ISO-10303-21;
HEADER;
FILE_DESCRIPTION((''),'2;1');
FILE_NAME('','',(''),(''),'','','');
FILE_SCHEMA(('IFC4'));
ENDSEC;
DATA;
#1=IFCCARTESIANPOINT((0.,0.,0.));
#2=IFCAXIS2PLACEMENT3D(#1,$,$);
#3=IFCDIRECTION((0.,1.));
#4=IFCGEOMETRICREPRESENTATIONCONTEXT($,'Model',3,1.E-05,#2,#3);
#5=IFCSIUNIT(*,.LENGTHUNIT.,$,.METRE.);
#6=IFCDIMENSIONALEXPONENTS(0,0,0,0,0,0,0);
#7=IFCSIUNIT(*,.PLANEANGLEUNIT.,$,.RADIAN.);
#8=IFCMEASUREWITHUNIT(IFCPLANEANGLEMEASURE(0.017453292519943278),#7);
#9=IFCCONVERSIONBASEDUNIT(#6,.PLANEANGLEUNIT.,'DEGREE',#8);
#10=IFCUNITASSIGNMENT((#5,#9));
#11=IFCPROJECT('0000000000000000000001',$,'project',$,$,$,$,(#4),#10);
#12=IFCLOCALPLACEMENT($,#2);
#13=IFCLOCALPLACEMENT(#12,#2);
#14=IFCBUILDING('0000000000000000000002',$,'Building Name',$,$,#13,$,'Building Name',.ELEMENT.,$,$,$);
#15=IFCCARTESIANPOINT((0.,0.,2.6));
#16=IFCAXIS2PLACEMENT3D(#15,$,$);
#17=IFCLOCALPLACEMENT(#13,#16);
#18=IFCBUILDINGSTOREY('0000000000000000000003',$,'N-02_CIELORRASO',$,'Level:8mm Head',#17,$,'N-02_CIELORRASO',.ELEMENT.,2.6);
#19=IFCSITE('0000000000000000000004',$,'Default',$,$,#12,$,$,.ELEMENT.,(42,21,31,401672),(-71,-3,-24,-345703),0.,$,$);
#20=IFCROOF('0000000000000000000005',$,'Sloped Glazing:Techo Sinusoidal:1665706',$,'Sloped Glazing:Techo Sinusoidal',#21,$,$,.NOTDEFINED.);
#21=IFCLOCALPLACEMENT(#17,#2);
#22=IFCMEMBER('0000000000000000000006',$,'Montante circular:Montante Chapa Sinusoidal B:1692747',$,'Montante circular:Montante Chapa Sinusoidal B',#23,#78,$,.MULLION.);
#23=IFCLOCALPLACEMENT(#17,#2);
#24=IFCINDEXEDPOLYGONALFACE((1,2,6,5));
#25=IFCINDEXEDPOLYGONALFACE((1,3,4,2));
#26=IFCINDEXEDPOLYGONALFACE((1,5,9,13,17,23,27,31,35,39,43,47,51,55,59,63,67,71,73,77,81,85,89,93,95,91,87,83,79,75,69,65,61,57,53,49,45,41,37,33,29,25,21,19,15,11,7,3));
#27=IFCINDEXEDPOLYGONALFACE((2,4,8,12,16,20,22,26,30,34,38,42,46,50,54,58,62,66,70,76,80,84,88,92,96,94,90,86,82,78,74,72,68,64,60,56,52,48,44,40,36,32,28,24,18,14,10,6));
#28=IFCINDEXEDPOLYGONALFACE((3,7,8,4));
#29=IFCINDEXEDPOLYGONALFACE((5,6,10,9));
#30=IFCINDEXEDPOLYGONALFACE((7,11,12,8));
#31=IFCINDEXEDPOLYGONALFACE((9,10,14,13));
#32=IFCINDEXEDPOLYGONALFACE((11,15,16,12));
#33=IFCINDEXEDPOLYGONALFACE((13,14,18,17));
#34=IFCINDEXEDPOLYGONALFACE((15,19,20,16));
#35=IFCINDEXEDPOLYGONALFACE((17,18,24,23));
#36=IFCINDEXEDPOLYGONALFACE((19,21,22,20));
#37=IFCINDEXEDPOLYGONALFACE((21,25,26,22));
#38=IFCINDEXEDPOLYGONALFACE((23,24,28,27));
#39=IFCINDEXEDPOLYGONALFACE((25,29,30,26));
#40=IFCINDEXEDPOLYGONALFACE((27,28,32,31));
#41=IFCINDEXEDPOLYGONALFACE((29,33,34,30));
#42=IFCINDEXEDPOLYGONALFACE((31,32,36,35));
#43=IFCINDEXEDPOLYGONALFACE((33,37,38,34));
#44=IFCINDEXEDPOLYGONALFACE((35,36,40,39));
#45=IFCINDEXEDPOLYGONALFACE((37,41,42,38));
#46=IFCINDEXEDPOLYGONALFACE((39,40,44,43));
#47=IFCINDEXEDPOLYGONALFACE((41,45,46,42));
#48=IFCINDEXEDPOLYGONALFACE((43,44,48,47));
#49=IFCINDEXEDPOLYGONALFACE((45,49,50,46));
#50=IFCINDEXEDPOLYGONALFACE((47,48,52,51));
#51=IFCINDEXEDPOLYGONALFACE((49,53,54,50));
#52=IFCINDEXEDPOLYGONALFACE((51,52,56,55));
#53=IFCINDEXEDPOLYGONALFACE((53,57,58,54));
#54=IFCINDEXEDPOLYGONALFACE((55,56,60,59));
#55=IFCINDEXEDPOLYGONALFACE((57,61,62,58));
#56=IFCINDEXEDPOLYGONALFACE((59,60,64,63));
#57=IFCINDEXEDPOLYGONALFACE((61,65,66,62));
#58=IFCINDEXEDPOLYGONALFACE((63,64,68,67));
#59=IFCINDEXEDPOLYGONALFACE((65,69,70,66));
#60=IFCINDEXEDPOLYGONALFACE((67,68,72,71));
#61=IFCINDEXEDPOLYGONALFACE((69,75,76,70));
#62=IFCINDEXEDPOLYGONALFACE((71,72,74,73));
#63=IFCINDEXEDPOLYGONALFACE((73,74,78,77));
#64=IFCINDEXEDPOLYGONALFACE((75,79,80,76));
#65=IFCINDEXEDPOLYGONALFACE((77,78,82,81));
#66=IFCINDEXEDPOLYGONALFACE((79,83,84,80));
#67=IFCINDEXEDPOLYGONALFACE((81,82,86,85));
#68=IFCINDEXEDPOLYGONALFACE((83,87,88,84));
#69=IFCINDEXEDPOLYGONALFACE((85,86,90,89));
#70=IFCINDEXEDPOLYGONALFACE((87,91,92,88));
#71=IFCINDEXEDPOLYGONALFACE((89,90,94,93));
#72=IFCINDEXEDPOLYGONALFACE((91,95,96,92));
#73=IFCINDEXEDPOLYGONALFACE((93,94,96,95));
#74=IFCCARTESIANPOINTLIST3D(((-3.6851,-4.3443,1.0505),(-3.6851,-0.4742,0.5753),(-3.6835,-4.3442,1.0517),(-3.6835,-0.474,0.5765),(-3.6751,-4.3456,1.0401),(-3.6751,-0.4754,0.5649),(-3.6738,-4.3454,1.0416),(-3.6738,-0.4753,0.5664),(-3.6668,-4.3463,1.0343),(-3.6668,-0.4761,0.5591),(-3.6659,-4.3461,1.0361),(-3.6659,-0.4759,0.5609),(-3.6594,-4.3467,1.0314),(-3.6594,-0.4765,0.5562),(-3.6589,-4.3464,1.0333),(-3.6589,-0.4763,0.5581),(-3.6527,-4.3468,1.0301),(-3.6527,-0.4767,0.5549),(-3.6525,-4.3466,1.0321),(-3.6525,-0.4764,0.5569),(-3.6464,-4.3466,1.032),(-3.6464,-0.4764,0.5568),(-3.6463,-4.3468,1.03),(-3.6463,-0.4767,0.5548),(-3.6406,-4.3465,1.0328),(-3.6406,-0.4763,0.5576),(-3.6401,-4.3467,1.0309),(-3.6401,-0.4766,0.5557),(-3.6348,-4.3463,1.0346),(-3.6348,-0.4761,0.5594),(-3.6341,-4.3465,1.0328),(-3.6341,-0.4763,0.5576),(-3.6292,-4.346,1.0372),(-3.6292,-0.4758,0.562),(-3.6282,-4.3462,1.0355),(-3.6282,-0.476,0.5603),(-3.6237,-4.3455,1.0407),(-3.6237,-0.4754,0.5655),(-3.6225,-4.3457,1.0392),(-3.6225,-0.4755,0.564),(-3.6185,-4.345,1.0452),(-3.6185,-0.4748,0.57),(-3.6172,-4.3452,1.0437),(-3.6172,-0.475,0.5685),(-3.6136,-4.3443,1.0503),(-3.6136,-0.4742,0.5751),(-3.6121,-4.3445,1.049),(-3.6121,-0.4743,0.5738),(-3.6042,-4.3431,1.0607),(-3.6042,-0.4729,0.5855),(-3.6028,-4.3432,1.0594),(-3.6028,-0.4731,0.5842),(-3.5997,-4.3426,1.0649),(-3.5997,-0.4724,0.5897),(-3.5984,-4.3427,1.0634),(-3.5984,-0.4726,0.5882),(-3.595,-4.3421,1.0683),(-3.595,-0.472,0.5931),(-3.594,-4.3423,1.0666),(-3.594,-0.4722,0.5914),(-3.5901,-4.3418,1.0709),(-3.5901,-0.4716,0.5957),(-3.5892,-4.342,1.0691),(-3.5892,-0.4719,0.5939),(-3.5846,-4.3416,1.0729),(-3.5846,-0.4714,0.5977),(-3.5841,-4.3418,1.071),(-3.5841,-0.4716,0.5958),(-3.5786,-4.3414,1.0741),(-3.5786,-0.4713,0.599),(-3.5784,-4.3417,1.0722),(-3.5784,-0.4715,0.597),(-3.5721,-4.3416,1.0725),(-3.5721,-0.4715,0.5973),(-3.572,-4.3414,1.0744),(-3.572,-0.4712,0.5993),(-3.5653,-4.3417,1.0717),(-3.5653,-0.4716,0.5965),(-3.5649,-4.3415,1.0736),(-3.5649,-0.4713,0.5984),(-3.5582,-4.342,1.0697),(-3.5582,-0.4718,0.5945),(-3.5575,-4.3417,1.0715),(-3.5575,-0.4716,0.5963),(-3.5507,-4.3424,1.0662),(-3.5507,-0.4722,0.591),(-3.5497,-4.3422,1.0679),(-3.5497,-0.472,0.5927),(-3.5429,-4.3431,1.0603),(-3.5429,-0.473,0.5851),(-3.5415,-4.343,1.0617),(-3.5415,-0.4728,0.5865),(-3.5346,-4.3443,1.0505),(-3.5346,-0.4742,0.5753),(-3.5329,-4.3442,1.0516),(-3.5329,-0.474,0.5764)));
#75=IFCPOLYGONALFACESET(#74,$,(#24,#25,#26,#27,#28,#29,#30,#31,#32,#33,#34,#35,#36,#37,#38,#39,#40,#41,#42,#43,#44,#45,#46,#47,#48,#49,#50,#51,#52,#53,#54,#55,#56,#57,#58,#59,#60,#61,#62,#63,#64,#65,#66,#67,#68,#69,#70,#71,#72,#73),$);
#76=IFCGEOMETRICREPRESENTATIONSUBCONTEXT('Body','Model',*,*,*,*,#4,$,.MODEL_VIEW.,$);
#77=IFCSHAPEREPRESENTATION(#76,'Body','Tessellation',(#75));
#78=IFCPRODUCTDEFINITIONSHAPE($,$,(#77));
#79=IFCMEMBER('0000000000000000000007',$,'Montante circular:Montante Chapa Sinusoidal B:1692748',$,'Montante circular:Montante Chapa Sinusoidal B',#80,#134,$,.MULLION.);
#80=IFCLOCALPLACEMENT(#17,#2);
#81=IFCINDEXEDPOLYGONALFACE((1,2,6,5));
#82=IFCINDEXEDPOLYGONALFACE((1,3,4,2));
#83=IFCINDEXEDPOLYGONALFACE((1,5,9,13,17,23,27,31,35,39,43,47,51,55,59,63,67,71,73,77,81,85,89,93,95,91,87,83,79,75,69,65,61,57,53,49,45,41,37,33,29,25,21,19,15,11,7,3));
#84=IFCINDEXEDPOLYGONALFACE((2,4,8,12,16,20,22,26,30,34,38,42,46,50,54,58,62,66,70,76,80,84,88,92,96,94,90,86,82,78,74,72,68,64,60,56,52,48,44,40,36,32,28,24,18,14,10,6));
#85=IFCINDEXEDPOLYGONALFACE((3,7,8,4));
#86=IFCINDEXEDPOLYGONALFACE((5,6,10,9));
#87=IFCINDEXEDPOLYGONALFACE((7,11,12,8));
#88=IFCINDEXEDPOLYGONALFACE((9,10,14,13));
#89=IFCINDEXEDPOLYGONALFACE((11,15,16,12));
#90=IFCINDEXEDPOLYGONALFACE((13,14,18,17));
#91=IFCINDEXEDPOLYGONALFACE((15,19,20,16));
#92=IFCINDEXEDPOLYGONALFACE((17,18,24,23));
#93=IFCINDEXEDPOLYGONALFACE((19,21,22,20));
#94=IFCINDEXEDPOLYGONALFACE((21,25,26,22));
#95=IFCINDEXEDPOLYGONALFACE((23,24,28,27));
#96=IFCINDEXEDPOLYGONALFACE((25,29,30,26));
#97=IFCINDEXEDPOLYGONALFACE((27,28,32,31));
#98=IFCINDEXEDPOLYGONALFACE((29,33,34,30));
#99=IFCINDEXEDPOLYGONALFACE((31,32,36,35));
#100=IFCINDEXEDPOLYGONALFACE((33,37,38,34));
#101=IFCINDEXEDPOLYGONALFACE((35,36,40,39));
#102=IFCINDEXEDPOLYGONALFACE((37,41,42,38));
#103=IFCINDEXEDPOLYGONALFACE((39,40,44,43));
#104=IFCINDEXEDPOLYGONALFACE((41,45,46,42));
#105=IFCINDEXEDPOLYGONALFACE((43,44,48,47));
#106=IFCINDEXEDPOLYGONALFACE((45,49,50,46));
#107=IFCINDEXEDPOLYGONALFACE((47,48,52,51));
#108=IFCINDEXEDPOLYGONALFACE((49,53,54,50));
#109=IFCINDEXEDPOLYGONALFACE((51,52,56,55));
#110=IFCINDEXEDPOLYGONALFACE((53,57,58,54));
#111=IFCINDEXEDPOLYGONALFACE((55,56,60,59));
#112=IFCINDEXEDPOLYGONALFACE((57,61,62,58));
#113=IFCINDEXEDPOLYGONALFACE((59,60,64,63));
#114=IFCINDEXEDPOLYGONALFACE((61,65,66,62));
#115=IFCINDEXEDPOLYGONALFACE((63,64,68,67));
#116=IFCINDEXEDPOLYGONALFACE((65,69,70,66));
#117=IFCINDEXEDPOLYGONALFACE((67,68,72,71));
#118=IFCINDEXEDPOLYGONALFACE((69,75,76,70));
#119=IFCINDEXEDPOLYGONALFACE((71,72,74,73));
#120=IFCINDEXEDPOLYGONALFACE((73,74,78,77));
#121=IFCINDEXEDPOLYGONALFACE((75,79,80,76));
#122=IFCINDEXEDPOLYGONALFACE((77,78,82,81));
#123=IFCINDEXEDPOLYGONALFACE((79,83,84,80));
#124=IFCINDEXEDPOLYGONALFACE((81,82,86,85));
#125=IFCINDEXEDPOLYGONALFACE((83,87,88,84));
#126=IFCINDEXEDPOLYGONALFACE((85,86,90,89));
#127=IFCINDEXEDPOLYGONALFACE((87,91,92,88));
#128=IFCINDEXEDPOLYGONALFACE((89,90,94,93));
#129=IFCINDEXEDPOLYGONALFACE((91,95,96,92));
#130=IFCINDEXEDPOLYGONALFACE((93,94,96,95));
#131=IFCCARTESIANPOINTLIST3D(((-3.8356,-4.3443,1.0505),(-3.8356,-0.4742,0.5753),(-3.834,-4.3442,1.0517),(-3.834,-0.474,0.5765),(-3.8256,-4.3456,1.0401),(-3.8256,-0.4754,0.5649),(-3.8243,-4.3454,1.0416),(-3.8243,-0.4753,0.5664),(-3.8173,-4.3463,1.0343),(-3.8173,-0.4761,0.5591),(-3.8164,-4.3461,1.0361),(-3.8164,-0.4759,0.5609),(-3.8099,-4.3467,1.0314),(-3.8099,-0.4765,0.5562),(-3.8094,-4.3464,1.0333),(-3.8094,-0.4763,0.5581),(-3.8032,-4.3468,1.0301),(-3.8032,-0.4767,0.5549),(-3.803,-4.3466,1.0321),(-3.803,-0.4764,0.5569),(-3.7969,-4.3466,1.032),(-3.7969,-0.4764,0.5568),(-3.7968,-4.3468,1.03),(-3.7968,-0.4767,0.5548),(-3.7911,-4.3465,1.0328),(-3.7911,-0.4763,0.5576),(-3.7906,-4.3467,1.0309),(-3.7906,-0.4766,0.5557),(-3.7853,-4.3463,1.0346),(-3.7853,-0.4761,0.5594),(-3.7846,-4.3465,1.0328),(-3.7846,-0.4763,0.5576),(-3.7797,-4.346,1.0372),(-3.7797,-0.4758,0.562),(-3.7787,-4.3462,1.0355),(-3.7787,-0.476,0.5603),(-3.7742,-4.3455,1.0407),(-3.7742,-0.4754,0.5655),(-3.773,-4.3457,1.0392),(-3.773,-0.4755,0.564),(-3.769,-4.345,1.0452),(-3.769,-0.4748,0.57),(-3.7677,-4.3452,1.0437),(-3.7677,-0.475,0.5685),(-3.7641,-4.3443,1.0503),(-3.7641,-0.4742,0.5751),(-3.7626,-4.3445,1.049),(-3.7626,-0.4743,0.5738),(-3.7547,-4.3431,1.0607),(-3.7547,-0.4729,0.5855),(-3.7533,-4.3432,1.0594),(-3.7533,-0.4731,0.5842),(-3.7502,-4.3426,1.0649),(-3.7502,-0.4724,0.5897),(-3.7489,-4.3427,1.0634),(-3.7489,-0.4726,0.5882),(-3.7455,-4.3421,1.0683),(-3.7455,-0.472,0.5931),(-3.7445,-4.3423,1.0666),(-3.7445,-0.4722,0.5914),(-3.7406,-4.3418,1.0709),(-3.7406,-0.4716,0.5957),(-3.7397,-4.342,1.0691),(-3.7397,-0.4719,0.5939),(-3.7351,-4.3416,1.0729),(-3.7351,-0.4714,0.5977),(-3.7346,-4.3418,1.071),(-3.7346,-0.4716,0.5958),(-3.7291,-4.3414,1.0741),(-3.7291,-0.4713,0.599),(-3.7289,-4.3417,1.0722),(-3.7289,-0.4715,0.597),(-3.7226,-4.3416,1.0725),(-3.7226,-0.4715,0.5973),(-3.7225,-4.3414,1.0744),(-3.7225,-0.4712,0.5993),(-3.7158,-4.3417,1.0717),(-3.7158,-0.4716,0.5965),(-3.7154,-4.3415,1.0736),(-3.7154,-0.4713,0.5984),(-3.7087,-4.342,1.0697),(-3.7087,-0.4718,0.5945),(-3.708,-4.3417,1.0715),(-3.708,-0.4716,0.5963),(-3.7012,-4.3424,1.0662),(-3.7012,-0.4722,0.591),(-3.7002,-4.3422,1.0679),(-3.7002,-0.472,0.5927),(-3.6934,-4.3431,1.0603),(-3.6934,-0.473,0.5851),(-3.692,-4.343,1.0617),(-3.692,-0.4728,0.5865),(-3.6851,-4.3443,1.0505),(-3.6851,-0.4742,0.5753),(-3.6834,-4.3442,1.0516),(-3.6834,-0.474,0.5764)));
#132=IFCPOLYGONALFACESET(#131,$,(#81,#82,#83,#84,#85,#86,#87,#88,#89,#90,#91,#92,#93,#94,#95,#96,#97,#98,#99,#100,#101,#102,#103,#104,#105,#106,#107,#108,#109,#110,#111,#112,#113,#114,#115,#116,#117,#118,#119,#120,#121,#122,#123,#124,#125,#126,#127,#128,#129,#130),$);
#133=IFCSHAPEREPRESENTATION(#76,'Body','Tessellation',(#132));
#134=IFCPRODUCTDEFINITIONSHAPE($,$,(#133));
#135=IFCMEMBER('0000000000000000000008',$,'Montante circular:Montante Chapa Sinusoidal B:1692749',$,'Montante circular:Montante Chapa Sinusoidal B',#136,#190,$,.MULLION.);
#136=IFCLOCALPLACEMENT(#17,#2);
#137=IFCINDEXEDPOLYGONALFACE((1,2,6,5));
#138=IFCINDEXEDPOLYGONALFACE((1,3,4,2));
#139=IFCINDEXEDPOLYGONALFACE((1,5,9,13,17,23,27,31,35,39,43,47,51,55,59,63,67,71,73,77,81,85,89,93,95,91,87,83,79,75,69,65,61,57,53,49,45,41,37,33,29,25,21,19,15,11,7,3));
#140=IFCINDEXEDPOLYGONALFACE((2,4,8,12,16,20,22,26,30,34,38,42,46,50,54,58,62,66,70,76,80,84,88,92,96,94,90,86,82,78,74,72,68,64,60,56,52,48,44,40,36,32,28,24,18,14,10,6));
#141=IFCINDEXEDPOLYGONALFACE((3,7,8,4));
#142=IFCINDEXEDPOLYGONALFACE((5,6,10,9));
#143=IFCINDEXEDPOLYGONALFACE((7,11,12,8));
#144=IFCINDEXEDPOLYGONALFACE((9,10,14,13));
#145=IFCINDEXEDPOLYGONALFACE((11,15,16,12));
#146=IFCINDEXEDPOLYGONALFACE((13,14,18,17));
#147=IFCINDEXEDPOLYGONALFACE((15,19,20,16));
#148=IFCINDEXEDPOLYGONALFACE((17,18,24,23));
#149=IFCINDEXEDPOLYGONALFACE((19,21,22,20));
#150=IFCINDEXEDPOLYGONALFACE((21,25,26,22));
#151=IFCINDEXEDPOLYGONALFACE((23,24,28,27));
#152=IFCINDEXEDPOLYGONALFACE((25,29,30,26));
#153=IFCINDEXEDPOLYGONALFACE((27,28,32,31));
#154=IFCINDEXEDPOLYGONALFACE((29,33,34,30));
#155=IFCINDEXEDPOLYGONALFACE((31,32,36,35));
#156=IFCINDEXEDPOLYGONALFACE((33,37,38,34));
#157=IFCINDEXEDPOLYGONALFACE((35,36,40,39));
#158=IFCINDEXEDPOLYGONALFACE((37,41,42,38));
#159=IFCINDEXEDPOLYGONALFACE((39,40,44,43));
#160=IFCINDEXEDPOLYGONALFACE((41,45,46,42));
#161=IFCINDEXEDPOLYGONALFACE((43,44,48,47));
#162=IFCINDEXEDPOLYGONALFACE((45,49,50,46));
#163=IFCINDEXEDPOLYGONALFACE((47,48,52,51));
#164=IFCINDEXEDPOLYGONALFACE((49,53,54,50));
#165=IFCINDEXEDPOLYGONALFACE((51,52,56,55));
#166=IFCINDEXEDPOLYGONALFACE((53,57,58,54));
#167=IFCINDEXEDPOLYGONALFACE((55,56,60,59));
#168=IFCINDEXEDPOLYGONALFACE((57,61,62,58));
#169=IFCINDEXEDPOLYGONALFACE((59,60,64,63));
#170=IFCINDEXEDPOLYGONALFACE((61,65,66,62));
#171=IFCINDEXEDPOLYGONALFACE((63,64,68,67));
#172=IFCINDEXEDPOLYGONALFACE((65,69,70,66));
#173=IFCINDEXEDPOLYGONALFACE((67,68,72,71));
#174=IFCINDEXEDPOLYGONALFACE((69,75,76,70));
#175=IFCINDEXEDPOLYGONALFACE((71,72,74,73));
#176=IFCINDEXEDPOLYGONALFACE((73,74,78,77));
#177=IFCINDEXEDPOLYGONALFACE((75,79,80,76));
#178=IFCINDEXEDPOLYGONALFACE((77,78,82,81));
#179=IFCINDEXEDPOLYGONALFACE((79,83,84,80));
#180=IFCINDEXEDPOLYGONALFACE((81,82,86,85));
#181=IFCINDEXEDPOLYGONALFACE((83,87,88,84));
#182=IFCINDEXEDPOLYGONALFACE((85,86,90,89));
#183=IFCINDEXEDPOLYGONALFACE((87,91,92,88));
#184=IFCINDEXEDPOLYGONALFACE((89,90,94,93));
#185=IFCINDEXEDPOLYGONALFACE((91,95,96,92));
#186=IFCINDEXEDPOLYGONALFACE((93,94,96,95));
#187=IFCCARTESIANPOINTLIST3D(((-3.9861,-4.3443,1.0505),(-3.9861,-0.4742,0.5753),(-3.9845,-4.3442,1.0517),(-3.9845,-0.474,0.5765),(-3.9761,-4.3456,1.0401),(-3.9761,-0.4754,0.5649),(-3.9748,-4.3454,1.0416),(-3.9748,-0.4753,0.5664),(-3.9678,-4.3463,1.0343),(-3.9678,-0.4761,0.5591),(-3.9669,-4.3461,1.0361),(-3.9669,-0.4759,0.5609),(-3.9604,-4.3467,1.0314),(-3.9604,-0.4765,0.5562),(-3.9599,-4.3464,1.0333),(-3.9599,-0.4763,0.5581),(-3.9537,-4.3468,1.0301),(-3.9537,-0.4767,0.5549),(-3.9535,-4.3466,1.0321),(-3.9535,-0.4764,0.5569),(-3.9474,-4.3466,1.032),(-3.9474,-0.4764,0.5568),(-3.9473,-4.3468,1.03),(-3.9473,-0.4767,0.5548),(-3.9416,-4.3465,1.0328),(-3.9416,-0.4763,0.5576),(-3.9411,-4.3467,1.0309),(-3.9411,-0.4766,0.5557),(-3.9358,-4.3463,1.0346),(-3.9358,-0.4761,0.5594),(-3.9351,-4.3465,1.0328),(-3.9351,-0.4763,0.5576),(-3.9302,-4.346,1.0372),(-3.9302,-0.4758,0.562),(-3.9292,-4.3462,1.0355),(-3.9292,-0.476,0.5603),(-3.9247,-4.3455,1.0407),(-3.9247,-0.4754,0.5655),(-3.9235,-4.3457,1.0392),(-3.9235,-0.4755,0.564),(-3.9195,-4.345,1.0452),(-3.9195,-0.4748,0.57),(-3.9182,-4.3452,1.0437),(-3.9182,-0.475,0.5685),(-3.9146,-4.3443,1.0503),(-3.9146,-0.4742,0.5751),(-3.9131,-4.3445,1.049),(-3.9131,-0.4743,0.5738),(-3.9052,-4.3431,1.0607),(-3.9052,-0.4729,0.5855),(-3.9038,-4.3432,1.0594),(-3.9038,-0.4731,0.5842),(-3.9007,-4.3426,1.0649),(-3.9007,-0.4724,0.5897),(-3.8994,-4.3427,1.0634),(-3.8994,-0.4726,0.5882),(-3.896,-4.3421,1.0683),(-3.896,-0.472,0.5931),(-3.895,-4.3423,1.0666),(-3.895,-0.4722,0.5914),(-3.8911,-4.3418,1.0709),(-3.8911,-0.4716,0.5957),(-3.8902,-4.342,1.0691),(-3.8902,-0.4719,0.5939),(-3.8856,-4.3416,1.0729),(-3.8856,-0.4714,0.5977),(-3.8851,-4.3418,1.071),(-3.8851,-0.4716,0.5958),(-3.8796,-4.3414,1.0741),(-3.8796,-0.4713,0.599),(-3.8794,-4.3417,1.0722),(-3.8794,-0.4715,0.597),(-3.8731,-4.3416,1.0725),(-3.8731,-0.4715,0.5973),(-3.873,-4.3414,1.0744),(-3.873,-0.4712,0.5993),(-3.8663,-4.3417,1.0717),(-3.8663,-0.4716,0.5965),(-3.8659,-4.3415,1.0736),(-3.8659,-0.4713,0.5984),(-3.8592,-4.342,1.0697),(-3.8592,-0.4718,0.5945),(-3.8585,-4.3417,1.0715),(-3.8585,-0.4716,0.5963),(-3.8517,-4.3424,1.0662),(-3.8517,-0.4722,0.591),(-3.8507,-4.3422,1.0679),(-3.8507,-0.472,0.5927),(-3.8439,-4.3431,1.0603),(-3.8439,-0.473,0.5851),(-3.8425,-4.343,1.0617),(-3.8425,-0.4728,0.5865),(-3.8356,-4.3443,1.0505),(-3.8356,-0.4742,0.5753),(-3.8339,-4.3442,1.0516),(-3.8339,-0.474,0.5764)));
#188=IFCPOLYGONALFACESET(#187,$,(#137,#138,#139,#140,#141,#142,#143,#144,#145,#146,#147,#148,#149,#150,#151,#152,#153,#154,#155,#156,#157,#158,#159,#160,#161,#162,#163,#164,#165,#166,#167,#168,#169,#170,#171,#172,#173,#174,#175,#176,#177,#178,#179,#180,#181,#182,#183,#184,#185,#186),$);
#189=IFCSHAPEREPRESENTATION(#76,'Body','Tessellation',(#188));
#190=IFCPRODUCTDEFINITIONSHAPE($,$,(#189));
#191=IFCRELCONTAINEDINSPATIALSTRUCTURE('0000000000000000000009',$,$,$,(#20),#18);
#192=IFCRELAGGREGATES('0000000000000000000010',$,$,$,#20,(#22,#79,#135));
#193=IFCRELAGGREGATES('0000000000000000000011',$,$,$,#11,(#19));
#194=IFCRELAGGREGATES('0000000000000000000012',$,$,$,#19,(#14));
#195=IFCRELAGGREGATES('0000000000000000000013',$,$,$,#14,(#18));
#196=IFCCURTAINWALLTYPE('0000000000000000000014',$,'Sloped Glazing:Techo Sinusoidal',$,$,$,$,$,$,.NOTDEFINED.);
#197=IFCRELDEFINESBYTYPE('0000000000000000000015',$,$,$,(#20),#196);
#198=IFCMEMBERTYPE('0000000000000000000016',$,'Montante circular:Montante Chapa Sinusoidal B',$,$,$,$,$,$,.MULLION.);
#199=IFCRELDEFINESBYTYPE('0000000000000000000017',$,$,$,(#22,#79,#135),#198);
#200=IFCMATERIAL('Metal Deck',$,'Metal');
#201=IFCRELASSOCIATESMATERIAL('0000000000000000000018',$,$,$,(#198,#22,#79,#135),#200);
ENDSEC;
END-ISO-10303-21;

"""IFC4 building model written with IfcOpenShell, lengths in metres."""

from ifc_helpers import new_model, entity, si_unit, converted_unit, direction, frame, origin, place, context, subcontext, project, spatial, indexed_curve, outline, extrude, source, transform, mapped, material, type_object, type_shapes, element, aggregate, save


model = new_model("IFC4")

# Units and contexts
model_context = context("Model", 3, precision=1e-05, world=origin(), true_north=direction((0.0, 1.0)))
body_context = subcontext(model_context, "Body", "Model", "MODEL_VIEW")
ifc_project = project(units=[si_unit("LENGTHUNIT", "METRE"), converted_unit("PLANEANGLEUNIT", "DEGREE", entity("IfcPlaneAngleMeasure", 0.017453292519943278), si_unit("PLANEANGLEUNIT", "RADIAN"), dimensions=[0, 0, 0, 0, 0, 0, 0])], contexts=[model_context])

# Site, building, storey
site_placement = place(None, origin())
site = spatial("IfcSite", under=ifc_project, at=site_placement, Name="Default", CompositionType="ELEMENT", RefLatitude=(42, 21, 31, 401672), RefLongitude=(-71, -3, -24, -345703), RefElevation=0.0)
building_placement = place(site_placement, origin())
building = spatial("IfcBuilding", under=site, at=building_placement, Name="Building Name", LongName="Building Name", CompositionType="ELEMENT")
storey_placement = place(building_placement, frame((0.0, 0.0, 2.6)))
storey = spatial("IfcBuildingStorey", under=building, at=storey_placement, Name="N-02_CIELORRASO", ObjectType="Level:8mm Head", LongName="N-02_CIELORRASO", CompositionType="ELEMENT", Elevation=2.6)

# Roof, members
curtain_wall_type = type_object("IfcCurtainWallType", Name="Sloped Glazing:Techo Sinusoidal", PredefinedType="NOTDEFINED")
ifc_material = material(Name="Metal Deck", Category="Metal")
roof_1_placement = place(storey_placement, frame((0.0, 0.0, -2.6)))
roof_1 = element("IfcRoof", 1, at=roof_1_placement, inside=storey, type_object=curtain_wall_type, Name="Sloped Glazing:Techo Sinusoidal:1665706", ObjectType="Sloped Glazing:Techo Sinusoidal", PredefinedType="NOTDEFINED")
member_type_1 = type_object("IfcMemberType", Name="Montante circular:Montante Chapa Sinusoidal B", PredefinedType="MULLION", material=ifc_material)
shared_shape_1 = source(origin(), body_context, "Body", "SweptSolid", [
    extrude(outline(indexed_curve([(0.0595, -0.0443), (0.0615, -0.0443), (0.0603, -0.031), (0.0572, -0.0213), (0.053, -0.0138), (0.0481, -0.0078), (0.0427, -0.003), (0.0372, 0.0005), (0.0315, 0.0029), (0.0259, 0.0044), (0.0203, 0.0051), (0.0146, 0.005), (0.0084, 0.0041), (-0.0053, 0.0009), (-0.0123, -0.0005), (-0.0191, -0.0012), (-0.0256, -0.001), (-0.0317, 0.0001), (-0.0375, 0.0019), (-0.0428, 0.0046), (-0.0477, 0.0081), (-0.0522, 0.0128), (-0.0563, 0.0191), (-0.0597, 0.0282), (-0.0617, 0.0421), (-0.0637, 0.042), (-0.0616, 0.0277), (-0.0581, 0.0182), (-0.0537, 0.0116), (-0.049, 0.0066), (-0.0438, 0.0028), (-0.0382, 0.0001), (-0.0322, -0.0019), (-0.0258, -0.003), (-0.019, -0.0032), (-0.012, -0.0025), (-0.0048, -0.0011), (0.0088, 0.0021), (0.0147, 0.003), (0.0202, 0.0031), (0.0255, 0.0024), (0.0309, 0.001), (0.0362, -0.0013), (0.0415, -0.0046), (0.0466, -0.0092), (0.0513, -0.0149), (0.0554, -0.0221), (0.0584, -0.0314), (0.0595, -0.0443)], self_intersect=False)), frame((-0.007, 0.0228, -3.8992), z_axis=(0.0, 0.0, 1.0), x_axis=(-0.819152, -0.573576, 0.0)), (0.0, 0.0, 1.0), 3.8992),
])
type_shapes(member_type_1, [shared_shape_1])
member_1_placement = place(roof_1_placement, frame((-3.6158, -4.3413, 3.6752), z_axis=(0.0, -0.992546, 0.121869), x_axis=(-1.0, 0.0, 0.0)))
member_1 = element("IfcMember", 2, at=member_1_placement, type_object=member_type_1, material=ifc_material, Name="Montante circular:Montante Chapa Sinusoidal B:1692747", ObjectType="Montante circular:Montante Chapa Sinusoidal B", PredefinedType="MULLION", context=body_context, shape_type="MappedRepresentation", body=[
    mapped(shared_shape_1, transform((0.0, 0.0, 0.0), scale=1.0)),
])
member_2_placement = place(roof_1_placement, frame((-3.7663, -4.3413, 3.6752), z_axis=(0.0, -0.992546, 0.121869), x_axis=(-1.0, 0.0, 0.0)))
member_2 = element("IfcMember", 3, at=member_2_placement, type_object=member_type_1, material=ifc_material, Name="Montante circular:Montante Chapa Sinusoidal B:1692748", ObjectType="Montante circular:Montante Chapa Sinusoidal B", PredefinedType="MULLION", context=body_context, shape_type="MappedRepresentation", body=[
    mapped(shared_shape_1, transform((0.0, 0.0, 0.0), scale=1.0)),
])
member_3_placement = place(roof_1_placement, frame((-3.9168, -4.3413, 3.6752), z_axis=(0.0, -0.992546, 0.121869), x_axis=(-1.0, 0.0, 0.0)))
member_3 = element("IfcMember", 4, at=member_3_placement, type_object=member_type_1, material=ifc_material, Name="Montante circular:Montante Chapa Sinusoidal B:1692749", ObjectType="Montante circular:Montante Chapa Sinusoidal B", PredefinedType="MULLION", context=body_context, shape_type="MappedRepresentation", body=[
    mapped(shared_shape_1, transform((0.0, 0.0, 0.0), scale=1.0)),
])
aggregate(roof_1, [member_1, member_2, member_3])

save(model, "model.ifc")
